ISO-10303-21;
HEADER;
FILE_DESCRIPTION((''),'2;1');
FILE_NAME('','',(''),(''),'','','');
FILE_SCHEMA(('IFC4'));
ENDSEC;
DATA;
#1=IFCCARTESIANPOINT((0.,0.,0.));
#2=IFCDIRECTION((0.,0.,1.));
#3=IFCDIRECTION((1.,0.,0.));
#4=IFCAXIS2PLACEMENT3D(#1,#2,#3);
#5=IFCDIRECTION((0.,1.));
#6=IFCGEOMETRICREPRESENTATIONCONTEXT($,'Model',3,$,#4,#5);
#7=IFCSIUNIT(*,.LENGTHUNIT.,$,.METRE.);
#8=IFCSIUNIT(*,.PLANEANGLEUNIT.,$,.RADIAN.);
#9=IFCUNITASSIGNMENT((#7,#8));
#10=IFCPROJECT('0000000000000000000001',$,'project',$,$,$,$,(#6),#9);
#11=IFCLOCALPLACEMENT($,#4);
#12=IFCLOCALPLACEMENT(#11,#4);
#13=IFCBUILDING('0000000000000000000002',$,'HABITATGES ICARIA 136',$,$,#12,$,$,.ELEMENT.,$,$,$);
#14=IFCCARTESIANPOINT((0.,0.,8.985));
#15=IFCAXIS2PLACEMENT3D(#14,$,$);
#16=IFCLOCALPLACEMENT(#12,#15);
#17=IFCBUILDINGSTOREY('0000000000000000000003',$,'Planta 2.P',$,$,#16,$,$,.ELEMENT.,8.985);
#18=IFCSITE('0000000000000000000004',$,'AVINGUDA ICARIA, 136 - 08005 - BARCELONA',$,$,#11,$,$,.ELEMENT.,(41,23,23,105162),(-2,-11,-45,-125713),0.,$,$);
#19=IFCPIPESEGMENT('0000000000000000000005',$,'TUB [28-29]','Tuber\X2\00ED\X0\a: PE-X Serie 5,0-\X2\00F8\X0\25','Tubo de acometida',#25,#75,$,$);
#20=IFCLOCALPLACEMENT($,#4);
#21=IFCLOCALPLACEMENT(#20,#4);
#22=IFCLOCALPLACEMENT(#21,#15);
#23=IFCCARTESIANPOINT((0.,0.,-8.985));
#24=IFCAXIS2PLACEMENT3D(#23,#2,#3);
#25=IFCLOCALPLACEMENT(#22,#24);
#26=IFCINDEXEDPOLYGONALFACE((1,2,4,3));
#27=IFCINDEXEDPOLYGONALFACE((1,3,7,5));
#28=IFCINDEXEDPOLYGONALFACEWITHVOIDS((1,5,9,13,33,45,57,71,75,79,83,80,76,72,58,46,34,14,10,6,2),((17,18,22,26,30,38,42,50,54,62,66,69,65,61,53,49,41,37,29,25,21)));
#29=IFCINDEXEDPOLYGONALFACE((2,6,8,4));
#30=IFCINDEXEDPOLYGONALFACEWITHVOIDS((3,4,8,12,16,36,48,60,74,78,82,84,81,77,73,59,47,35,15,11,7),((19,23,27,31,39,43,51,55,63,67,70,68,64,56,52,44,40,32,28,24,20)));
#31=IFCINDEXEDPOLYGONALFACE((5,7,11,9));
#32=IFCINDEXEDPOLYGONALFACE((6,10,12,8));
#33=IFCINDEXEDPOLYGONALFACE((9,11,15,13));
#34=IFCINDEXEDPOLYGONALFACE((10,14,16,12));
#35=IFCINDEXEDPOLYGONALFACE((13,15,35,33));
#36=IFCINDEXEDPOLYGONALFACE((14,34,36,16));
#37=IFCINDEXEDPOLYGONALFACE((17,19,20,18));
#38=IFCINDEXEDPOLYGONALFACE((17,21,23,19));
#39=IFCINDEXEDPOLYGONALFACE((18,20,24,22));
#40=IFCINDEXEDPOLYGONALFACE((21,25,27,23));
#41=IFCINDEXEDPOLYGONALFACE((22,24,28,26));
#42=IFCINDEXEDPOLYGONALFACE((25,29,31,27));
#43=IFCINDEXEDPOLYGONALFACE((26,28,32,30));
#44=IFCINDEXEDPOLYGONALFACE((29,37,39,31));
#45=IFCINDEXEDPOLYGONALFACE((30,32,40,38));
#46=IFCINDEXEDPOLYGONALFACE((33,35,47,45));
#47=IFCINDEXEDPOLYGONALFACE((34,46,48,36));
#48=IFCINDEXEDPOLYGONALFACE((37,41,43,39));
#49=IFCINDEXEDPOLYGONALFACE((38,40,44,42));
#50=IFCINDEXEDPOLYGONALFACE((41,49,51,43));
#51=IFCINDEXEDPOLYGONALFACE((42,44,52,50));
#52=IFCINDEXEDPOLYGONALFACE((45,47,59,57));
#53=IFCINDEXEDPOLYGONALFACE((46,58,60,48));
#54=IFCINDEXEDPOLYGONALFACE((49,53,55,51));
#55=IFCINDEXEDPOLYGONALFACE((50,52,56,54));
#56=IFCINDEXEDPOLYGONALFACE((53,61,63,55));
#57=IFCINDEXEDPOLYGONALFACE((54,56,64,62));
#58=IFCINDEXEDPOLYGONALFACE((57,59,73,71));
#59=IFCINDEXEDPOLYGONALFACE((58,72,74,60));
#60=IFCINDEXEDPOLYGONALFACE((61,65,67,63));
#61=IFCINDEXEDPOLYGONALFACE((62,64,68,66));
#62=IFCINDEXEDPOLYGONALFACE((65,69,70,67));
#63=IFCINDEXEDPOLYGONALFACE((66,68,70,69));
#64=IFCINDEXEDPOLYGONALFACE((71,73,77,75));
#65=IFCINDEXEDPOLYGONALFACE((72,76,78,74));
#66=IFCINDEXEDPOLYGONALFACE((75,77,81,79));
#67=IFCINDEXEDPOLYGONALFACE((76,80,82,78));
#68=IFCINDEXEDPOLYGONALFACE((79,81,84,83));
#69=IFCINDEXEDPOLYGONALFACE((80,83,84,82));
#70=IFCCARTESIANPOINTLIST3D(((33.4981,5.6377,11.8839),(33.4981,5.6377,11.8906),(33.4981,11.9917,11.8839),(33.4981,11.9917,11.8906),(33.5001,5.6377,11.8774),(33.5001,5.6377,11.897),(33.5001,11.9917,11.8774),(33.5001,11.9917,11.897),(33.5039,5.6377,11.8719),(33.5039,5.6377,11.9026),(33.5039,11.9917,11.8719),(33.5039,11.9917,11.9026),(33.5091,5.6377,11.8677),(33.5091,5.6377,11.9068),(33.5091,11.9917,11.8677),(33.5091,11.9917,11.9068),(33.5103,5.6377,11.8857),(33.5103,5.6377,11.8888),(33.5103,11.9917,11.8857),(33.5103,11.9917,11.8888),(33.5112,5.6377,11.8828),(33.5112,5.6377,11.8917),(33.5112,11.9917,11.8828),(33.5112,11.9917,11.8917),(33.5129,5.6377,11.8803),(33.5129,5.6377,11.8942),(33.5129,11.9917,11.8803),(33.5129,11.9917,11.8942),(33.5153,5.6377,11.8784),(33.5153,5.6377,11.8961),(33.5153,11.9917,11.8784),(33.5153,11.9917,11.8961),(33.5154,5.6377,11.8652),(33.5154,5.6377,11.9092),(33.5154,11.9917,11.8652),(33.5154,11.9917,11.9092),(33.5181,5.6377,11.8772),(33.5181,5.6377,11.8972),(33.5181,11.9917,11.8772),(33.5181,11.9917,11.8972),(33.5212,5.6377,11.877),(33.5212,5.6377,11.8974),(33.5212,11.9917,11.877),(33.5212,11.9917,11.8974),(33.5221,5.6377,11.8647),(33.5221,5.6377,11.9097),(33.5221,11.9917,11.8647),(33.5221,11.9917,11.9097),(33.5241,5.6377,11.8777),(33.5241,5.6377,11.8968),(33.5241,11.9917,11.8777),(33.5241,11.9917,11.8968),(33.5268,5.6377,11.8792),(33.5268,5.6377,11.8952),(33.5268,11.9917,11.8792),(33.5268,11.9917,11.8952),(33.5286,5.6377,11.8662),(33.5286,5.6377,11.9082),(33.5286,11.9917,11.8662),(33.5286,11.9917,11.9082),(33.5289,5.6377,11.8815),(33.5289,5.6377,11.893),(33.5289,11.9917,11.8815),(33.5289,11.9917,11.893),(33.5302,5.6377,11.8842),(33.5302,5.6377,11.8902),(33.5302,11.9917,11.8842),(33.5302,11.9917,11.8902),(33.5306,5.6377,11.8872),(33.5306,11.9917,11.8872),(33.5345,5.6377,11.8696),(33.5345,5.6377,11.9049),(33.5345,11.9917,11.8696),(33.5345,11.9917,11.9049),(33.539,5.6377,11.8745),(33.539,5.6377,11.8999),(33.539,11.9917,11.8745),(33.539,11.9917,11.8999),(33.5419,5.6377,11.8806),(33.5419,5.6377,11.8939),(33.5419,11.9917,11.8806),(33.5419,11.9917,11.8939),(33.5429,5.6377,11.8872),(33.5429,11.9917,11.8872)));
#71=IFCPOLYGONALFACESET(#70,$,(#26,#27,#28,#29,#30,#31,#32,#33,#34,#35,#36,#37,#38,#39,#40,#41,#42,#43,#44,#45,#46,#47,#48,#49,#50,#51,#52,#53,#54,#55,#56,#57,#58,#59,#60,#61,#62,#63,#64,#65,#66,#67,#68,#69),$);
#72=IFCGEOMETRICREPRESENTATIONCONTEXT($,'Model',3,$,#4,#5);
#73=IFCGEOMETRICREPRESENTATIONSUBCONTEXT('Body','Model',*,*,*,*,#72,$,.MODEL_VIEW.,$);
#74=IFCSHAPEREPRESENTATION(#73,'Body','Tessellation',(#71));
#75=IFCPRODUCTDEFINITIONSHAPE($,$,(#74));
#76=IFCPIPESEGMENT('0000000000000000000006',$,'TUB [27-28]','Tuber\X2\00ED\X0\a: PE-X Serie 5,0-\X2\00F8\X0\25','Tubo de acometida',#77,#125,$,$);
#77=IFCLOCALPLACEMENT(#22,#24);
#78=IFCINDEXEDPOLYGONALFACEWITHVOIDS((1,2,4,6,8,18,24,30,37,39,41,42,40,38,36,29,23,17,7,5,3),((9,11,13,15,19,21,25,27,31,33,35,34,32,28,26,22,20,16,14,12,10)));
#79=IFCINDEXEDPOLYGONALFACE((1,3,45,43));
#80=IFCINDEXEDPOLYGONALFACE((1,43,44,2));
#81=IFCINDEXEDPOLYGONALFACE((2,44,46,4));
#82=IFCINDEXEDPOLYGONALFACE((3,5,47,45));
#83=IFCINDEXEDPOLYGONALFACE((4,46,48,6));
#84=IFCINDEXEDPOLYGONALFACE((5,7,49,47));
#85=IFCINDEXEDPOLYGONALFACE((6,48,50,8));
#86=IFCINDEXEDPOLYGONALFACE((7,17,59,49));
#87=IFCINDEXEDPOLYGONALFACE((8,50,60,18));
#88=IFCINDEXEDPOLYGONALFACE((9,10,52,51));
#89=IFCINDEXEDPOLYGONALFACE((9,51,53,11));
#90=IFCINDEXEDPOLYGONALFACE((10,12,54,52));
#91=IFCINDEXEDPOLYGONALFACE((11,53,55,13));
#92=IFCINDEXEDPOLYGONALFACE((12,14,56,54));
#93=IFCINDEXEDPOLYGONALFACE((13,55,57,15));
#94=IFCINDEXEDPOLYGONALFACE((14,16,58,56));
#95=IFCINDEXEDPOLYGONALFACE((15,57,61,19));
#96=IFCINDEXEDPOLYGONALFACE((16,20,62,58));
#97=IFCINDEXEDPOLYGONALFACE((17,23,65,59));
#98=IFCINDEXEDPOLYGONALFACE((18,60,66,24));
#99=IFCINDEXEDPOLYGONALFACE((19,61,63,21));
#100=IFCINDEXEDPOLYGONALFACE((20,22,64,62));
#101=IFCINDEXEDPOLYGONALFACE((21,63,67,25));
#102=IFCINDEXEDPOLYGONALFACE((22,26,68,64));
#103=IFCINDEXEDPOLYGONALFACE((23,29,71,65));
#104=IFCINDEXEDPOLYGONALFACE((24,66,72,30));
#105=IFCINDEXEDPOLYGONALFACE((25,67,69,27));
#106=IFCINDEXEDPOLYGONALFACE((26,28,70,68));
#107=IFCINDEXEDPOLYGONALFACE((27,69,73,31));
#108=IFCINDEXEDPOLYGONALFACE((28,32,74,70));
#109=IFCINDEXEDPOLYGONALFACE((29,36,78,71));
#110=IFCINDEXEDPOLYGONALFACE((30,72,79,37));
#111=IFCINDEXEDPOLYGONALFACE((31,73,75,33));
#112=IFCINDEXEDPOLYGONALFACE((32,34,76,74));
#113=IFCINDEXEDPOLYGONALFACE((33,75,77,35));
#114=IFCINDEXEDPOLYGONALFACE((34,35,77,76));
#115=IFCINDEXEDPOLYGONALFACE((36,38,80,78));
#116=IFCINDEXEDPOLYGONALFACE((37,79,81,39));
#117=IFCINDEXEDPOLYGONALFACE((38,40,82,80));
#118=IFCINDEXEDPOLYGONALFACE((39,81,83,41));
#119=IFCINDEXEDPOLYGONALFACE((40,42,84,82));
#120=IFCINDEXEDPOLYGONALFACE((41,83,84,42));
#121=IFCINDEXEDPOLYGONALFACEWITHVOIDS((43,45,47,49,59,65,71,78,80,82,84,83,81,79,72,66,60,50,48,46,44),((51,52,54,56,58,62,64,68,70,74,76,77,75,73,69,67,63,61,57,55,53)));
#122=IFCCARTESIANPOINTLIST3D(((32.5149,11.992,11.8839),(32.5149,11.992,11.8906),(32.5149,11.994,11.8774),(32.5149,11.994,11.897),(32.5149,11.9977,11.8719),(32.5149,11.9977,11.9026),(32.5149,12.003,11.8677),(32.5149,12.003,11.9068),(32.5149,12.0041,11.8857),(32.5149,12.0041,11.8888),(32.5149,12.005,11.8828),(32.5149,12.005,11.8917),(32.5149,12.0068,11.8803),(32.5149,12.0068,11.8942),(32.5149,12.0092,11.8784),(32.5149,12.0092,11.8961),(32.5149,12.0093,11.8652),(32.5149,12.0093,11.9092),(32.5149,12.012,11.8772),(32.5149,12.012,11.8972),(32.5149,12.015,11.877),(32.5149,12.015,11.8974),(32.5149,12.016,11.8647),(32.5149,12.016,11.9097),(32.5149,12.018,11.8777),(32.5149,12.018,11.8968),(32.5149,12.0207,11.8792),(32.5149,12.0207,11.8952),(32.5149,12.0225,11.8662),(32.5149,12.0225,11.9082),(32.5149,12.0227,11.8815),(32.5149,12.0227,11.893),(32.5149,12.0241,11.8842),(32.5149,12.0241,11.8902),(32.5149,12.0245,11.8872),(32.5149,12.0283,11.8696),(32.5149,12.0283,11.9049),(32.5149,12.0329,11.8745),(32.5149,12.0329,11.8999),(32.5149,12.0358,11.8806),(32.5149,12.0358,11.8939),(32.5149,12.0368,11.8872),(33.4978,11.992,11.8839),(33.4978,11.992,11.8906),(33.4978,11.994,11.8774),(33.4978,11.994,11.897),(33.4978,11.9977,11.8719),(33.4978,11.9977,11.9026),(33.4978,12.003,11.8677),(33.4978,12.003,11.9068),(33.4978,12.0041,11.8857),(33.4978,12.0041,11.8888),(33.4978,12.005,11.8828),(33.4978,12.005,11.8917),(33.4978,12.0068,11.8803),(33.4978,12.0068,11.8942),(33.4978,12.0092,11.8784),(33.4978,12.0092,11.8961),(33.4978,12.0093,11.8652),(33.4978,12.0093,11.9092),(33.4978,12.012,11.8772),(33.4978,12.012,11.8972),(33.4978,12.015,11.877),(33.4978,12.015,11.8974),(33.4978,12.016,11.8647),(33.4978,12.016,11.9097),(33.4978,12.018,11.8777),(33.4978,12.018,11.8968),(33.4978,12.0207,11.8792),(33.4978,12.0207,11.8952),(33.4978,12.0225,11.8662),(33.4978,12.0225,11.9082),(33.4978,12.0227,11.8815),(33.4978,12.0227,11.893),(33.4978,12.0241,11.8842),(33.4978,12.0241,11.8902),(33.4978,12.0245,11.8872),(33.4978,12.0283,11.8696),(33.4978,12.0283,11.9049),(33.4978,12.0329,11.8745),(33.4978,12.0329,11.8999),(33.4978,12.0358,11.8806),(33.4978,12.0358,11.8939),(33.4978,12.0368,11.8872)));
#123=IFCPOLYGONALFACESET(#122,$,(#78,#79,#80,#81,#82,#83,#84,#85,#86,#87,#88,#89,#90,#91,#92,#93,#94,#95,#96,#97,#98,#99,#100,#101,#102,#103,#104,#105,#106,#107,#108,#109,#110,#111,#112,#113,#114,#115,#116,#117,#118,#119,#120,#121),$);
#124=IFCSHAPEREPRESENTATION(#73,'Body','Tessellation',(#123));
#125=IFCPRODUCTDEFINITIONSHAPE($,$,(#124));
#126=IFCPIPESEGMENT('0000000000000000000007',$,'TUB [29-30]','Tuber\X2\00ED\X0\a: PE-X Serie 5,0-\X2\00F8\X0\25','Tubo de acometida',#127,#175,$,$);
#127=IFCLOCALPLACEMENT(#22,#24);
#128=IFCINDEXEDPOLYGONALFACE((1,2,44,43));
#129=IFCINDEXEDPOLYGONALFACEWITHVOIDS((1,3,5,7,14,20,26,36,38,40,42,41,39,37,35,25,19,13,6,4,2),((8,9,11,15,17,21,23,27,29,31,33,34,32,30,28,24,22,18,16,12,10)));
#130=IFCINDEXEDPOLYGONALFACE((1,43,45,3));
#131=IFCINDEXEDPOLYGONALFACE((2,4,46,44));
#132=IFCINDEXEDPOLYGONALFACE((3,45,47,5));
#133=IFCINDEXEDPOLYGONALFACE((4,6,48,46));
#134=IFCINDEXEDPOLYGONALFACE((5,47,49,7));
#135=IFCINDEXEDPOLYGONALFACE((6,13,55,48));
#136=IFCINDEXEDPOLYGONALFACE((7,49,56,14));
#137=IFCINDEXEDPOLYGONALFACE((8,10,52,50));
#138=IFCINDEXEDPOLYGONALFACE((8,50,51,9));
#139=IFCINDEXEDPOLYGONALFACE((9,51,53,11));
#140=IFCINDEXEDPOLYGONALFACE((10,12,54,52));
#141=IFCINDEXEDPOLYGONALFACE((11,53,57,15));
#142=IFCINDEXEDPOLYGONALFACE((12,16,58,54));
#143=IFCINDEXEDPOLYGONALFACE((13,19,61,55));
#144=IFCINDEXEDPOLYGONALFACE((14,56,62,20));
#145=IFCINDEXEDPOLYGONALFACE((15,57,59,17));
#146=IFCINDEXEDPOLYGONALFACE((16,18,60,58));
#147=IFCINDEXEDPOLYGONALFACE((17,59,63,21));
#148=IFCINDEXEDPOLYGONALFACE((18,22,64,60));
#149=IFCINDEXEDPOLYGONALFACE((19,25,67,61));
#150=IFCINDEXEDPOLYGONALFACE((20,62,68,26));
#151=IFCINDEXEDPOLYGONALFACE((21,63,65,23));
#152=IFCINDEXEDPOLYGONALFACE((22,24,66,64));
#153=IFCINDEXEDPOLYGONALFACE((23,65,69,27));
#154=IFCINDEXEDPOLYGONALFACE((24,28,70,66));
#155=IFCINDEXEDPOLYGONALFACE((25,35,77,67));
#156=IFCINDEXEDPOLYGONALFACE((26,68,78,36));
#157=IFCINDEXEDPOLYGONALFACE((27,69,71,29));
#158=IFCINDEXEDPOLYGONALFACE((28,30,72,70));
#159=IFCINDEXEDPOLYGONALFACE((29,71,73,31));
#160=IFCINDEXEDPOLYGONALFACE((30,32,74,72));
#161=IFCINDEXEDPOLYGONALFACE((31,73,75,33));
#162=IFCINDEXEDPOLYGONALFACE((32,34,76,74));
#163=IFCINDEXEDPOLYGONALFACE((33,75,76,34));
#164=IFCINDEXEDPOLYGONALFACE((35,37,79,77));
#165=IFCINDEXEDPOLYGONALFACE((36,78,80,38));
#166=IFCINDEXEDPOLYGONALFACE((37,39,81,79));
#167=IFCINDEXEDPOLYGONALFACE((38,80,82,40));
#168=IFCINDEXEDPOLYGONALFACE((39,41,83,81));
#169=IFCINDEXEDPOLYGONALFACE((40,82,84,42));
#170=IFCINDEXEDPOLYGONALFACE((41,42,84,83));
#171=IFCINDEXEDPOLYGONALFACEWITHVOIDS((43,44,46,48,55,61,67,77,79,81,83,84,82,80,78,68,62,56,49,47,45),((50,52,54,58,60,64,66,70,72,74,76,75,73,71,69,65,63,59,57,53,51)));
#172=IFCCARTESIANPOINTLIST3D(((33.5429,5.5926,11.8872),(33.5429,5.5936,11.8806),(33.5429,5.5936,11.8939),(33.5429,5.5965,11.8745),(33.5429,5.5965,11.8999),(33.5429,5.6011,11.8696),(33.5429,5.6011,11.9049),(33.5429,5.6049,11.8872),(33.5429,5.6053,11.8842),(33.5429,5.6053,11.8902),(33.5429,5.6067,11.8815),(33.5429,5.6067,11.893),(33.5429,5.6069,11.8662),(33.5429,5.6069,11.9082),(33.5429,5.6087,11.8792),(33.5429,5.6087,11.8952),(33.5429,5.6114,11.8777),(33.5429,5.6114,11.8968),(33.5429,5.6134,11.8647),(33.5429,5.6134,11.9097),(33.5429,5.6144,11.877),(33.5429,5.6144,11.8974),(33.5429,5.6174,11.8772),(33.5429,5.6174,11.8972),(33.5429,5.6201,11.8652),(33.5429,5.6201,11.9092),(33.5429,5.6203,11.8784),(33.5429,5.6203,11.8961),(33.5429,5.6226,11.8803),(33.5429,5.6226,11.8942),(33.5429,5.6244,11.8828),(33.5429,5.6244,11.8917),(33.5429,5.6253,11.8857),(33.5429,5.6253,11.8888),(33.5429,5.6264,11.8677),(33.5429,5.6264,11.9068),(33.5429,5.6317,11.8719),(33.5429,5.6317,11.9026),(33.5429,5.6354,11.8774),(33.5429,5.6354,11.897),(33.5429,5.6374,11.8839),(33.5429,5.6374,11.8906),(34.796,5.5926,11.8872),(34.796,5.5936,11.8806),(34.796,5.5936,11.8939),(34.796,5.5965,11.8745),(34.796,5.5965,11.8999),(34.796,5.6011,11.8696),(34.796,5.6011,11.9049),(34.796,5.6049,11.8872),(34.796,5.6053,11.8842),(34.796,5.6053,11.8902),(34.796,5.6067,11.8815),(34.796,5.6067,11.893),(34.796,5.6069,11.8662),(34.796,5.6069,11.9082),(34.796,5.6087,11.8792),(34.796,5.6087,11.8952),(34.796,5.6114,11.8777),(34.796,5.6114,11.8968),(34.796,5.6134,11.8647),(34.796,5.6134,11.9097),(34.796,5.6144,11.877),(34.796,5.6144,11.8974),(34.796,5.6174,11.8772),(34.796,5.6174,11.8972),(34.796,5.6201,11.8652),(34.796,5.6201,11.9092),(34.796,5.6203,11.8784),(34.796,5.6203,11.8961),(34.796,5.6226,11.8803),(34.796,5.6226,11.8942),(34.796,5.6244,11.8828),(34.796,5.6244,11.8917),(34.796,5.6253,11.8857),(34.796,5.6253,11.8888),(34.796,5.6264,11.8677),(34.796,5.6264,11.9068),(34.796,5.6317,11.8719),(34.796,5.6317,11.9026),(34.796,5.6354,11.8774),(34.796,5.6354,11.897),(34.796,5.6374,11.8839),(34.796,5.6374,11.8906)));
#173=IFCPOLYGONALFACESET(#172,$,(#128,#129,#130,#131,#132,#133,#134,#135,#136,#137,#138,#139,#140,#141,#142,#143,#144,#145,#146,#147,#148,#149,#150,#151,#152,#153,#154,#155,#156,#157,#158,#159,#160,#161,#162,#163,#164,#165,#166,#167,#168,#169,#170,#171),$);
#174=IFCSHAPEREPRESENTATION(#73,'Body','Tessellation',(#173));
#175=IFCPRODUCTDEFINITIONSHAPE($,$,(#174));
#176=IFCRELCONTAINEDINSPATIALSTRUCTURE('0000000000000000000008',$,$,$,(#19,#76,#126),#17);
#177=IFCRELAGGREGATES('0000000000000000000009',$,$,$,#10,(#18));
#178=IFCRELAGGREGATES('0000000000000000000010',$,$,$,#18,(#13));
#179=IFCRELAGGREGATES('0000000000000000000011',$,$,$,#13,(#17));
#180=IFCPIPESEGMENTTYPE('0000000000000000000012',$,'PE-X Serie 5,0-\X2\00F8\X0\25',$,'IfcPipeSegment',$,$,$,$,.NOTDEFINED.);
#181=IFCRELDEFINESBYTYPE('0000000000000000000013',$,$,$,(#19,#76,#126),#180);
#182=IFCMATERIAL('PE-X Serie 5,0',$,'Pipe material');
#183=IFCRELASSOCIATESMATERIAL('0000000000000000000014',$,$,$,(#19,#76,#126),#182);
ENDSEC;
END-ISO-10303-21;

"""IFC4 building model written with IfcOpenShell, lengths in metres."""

from ifc_helpers import new_model, si_unit, direction, frame, origin_with_axes, origin_2d_with_axis, place, context, subcontext, project, spatial, hollow_circle, extrude, material, type_object, element, save


model = new_model("IFC4")

# Units and contexts
model_context_1 = context("Model", 3, world=origin_with_axes(), true_north=direction((0.0, 1.0)))
model_context_2 = context("Model", 3, world=origin_with_axes(), true_north=direction((0.0, 1.0)))
body_context_1 = subcontext(model_context_2, "Body", "Model", "MODEL_VIEW")
ifc_project = project(units=[si_unit("LENGTHUNIT", "METRE"), si_unit("PLANEANGLEUNIT", "RADIAN")], contexts=[model_context_1])

# Site, building, storey
site_placement = place(None, origin_with_axes())
site = spatial("IfcSite", under=ifc_project, at=site_placement, Name="AVINGUDA ICARIA, 136 - 08005 - BARCELONA", CompositionType="ELEMENT", RefLatitude=(41, 23, 23, 105162), RefLongitude=(-2, -11, -45, -125713), RefElevation=0.0)
building_placement = place(site_placement, origin_with_axes())
building = spatial("IfcBuilding", under=site, at=building_placement, Name="HABITATGES ICARIA 136", CompositionType="ELEMENT")
storey_placement = place(building_placement, frame((0.0, 0.0, 8.985)))
storey = spatial("IfcBuildingStorey", under=building, at=storey_placement, Name="Planta 2.P", CompositionType="ELEMENT", Elevation=8.985)

# Pipe segments
ifc_material_1 = material(Name="PE-X Serie 5,0", Category="Pipe material")
pipe_segment_type = type_object("IfcPipeSegmentType", Name="PE-X Serie 5,0-ø25", ApplicableOccurrence="IfcPipeSegment", PredefinedType="NOTDEFINED")
placement_1 = place(None, origin_with_axes())
placement_2 = place(placement_1, origin_with_axes())
placement_3 = place(placement_2, frame((0.0, 0.0, 8.985)))
pipe_segment_1_placement = place(placement_3, frame((0.0, 0.0, -8.985), z_axis=(0.0, 0.0, 1.0), x_axis=(1.0, 0.0, 0.0)))
element("IfcPipeSegment", 1, at=pipe_segment_1_placement, inside=storey, type_object=pipe_segment_type, material=ifc_material_1, Name="TUB [28-29]", Description="Tubería: PE-X Serie 5,0-ø25", ObjectType="Tubo de acometida", context=body_context_1, shape_type="SweptSolid", body=[
    extrude(hollow_circle(Radius=0.0226, WallThickness=0.0123, at=origin_2d_with_axis()), frame((33.5204, 11.9917, 11.8872), z_axis=(0.0, -1.0, 0.0), x_axis=(1.0, 0.0, 0.0)), (0.0, 0.0, 1.0), 6.354),
])
pipe_segment_2_placement = place(placement_3, frame((0.0, 0.0, -8.985), z_axis=(0.0, 0.0, 1.0), x_axis=(1.0, 0.0, 0.0)))
element("IfcPipeSegment", 2, at=pipe_segment_2_placement, inside=storey, type_object=pipe_segment_type, material=ifc_material_1, Name="TUB [27-28]", Description="Tubería: PE-X Serie 5,0-ø25", ObjectType="Tubo de acometida", context=body_context_1, shape_type="SweptSolid", body=[
    extrude(hollow_circle(Radius=0.0226, WallThickness=0.0123, at=origin_2d_with_axis()), frame((32.5149, 12.0143, 11.8872), z_axis=(1.0, 0.0, 0.0), x_axis=(0.0, 1.0, 0.0)), (0.0, 0.0, 1.0), 0.983),
])
pipe_segment_3_placement = place(placement_3, frame((0.0, 0.0, -8.985), z_axis=(0.0, 0.0, 1.0), x_axis=(1.0, 0.0, 0.0)))
element("IfcPipeSegment", 3, at=pipe_segment_3_placement, inside=storey, type_object=pipe_segment_type, material=ifc_material_1, Name="TUB [29-30]", Description="Tubería: PE-X Serie 5,0-ø25", ObjectType="Tubo de acometida", context=body_context_1, shape_type="SweptSolid", body=[
    extrude(hollow_circle(Radius=0.0226, WallThickness=0.0123, at=origin_2d_with_axis()), frame((34.796, 5.6151, 11.8872), z_axis=(-1.0, 0.0, 0.0), x_axis=(0.0, -1.0, 0.0)), (0.0, 0.0, 1.0), 1.253),
])

save(model, "model.ifc")
